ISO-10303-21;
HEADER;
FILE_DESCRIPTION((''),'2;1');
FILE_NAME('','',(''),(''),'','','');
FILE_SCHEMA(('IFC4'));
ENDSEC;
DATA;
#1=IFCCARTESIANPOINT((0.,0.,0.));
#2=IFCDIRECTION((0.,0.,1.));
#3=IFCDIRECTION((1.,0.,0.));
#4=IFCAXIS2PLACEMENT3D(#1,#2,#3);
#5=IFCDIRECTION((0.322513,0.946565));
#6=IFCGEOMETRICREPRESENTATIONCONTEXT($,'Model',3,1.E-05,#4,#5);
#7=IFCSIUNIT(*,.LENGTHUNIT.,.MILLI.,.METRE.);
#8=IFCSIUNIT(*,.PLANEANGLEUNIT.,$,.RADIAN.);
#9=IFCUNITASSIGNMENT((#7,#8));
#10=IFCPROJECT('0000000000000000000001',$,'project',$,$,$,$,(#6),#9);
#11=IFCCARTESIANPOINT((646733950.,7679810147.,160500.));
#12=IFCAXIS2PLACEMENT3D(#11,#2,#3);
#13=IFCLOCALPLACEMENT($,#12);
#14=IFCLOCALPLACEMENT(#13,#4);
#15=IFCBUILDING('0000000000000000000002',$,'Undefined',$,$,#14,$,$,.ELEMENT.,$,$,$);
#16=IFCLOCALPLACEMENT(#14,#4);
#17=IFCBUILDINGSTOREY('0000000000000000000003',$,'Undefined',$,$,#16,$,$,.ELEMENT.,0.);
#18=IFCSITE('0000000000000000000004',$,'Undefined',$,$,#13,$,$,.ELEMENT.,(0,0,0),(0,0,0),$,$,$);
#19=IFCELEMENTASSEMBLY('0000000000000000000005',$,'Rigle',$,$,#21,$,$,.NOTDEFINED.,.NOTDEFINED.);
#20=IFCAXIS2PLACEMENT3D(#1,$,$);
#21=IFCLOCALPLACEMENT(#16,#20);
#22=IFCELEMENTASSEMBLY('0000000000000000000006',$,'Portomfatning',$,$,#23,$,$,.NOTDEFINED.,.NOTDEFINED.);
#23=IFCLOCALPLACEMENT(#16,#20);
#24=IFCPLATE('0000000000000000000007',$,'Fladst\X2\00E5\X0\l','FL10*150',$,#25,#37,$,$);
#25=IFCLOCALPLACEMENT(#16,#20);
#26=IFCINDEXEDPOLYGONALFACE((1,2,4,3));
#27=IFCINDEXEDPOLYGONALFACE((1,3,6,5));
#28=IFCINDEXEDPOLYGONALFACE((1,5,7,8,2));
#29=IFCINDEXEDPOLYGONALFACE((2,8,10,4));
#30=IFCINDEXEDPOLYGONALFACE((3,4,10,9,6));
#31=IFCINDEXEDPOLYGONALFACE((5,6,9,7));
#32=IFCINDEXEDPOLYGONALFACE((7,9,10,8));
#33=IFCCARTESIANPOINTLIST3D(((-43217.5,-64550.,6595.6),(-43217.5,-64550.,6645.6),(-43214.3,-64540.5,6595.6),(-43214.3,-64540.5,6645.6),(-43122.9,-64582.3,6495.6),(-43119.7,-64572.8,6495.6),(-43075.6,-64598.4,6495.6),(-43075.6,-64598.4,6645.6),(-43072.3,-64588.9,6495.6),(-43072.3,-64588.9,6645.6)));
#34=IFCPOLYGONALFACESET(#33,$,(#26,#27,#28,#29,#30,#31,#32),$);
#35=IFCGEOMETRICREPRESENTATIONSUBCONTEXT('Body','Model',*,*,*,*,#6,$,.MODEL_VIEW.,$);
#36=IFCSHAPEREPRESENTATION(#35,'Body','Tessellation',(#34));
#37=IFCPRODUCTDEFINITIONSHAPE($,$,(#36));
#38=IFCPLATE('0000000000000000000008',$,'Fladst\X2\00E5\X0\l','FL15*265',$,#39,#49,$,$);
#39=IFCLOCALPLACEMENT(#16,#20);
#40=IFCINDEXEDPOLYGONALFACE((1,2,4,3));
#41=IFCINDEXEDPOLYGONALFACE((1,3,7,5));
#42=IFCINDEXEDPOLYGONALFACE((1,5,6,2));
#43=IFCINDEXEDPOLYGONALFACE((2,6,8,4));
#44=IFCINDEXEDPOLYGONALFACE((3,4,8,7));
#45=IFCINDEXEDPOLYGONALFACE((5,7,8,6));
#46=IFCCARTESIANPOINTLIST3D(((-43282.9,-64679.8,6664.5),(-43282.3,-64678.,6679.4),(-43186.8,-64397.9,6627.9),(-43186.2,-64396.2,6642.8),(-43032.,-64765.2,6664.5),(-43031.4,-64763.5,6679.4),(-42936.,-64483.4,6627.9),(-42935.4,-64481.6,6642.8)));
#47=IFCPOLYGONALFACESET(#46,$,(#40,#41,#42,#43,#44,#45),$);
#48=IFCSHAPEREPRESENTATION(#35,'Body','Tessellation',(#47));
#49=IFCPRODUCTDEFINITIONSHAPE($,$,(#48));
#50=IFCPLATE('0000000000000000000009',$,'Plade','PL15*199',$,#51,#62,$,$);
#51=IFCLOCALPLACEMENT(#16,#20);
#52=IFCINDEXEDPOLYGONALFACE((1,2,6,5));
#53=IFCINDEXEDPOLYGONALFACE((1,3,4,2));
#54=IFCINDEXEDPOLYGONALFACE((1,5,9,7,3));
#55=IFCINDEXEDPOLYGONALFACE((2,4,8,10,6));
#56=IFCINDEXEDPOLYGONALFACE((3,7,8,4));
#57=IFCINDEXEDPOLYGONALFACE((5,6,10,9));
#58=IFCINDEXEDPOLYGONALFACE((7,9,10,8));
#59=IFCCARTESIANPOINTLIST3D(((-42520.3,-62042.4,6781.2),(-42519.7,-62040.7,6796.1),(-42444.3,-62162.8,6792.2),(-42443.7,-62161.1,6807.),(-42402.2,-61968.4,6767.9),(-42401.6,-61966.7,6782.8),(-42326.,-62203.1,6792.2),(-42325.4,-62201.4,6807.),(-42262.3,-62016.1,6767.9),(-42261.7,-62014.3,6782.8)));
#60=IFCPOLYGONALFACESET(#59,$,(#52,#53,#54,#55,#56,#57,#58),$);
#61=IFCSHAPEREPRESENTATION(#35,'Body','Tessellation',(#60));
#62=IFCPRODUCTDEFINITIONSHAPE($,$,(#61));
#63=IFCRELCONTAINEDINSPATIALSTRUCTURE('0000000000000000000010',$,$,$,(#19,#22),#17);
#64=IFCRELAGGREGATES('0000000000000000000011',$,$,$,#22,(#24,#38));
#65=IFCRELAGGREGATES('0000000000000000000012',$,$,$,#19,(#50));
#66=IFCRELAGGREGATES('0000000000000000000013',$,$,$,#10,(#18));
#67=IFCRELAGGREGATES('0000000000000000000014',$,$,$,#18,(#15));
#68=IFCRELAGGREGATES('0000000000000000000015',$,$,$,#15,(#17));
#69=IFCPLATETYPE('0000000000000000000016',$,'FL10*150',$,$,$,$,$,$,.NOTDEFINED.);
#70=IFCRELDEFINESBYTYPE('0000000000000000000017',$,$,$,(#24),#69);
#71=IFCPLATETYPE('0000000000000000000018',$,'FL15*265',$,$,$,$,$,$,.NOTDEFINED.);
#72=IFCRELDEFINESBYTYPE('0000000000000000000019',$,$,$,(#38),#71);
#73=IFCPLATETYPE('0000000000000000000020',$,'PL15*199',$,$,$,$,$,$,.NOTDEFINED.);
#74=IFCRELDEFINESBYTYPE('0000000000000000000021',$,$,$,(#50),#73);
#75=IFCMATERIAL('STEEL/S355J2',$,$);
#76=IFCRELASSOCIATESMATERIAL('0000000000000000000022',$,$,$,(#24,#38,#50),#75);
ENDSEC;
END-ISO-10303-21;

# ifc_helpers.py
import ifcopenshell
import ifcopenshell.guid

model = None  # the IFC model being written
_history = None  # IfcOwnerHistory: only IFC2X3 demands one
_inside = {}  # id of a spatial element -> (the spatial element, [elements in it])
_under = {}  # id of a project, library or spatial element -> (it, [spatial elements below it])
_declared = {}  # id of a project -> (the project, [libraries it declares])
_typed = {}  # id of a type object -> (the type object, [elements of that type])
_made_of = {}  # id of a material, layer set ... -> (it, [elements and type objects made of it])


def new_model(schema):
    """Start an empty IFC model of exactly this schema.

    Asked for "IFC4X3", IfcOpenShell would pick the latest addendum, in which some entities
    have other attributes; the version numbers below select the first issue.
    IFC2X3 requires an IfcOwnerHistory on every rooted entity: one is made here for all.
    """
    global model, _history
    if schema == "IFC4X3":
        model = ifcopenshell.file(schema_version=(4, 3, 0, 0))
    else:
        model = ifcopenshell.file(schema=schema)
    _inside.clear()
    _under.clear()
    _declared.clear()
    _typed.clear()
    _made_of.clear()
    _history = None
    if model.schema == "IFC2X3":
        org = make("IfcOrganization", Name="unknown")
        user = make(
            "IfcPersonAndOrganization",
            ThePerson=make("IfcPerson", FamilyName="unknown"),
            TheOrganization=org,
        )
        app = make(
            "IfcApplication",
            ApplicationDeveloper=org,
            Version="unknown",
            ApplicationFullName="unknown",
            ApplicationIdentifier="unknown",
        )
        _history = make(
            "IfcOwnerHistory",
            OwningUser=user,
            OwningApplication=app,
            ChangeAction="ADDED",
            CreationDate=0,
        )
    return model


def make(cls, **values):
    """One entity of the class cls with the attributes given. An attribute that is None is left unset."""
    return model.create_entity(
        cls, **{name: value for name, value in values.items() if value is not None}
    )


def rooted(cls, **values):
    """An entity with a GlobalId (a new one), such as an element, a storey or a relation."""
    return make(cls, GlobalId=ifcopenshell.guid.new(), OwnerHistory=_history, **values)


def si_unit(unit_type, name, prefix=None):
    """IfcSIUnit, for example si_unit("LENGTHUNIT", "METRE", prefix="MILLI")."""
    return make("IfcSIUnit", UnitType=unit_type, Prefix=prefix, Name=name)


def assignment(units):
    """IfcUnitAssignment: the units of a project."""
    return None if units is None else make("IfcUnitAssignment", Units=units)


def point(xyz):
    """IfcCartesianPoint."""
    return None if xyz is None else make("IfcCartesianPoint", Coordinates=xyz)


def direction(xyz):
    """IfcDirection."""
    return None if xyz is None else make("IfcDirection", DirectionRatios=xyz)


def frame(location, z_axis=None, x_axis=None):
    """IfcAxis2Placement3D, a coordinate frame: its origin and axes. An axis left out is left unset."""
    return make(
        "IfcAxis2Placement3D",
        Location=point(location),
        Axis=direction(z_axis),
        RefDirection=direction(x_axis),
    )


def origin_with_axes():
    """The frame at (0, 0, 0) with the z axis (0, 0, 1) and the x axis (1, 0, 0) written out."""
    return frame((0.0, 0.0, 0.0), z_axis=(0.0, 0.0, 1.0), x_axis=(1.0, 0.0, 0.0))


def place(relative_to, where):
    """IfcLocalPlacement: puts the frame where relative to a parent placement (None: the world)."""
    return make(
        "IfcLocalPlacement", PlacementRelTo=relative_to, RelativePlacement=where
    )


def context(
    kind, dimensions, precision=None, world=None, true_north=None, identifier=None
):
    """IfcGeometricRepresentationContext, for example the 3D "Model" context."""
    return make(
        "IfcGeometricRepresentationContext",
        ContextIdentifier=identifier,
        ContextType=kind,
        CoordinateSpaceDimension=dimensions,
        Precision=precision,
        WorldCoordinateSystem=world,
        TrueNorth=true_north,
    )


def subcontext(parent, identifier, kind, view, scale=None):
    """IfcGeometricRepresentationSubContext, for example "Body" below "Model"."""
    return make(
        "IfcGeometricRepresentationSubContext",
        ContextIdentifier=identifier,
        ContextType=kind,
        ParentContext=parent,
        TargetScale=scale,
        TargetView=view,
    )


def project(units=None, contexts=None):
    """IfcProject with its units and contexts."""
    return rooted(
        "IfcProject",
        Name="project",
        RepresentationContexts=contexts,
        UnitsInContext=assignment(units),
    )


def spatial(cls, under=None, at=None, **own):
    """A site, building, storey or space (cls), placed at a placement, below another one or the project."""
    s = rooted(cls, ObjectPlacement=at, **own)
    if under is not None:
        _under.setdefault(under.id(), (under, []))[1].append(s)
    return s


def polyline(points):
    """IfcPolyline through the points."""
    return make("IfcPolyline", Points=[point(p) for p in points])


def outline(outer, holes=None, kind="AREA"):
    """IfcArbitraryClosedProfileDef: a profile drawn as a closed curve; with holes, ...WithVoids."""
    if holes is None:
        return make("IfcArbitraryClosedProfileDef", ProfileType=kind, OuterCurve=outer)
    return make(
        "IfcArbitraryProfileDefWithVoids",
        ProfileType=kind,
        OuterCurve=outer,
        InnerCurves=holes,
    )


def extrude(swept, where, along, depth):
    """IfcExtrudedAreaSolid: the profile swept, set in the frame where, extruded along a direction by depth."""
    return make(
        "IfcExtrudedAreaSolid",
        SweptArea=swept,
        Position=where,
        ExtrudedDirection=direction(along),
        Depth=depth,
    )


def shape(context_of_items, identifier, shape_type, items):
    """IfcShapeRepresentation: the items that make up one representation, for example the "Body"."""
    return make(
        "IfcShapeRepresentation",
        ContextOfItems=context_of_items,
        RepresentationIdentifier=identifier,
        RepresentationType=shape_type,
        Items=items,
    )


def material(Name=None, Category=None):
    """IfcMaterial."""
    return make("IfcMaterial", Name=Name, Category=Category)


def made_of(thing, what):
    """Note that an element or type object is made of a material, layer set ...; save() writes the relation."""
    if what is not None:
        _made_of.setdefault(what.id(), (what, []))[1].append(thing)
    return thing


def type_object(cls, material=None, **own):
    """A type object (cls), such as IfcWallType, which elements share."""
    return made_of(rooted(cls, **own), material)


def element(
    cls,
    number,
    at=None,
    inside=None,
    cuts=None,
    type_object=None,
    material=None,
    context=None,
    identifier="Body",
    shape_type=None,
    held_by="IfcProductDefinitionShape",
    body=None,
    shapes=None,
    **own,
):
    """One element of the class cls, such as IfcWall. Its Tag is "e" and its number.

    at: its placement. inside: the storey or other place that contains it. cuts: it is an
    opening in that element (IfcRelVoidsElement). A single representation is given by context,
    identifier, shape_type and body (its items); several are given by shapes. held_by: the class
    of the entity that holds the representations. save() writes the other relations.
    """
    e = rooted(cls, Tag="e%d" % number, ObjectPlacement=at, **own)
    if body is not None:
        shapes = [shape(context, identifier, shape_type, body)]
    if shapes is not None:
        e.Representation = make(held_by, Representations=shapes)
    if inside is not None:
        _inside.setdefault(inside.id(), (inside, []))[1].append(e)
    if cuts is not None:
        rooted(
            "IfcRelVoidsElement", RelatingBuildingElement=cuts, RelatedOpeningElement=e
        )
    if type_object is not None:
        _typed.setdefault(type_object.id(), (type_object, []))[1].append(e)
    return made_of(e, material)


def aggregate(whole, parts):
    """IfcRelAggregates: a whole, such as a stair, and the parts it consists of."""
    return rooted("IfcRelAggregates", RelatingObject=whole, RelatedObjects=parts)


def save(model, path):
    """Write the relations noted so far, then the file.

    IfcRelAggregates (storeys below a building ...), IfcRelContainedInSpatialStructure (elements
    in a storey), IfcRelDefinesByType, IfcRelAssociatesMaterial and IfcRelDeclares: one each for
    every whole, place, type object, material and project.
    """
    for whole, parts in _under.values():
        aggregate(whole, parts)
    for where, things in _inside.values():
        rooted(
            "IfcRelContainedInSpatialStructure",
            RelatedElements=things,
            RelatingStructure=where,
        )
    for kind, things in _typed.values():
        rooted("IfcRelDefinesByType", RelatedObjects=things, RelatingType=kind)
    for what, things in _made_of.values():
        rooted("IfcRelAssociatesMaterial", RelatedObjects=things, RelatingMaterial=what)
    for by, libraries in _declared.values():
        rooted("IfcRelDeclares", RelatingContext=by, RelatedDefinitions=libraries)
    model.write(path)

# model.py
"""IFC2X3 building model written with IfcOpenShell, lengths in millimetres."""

from ifc_helpers import new_model, si_unit, direction, frame, origin_with_axes, place, context, subcontext, project, spatial, polyline, outline, extrude, material, type_object, element, aggregate, save


model = new_model("IFC2X3")

# Units and contexts
model_context = context("Model", 3, precision=1e-05, world=origin_with_axes(), true_north=direction((0.322513, 0.946565)))
body_context = subcontext(model_context, "Body", "Model", "MODEL_VIEW")
ifc_project = project(units=[si_unit("LENGTHUNIT", "METRE", prefix="MILLI"), si_unit("PLANEANGLEUNIT", "RADIAN")], contexts=[model_context])

# Site, building, storey
site_placement = place(None, frame((646733950.0, 7679810147.0, 160500.0), z_axis=(0.0, 0.0, 1.0), x_axis=(1.0, 0.0, 0.0)))
site = spatial("IfcSite", under=ifc_project, at=site_placement, Name="Undefined", CompositionType="ELEMENT", RefLatitude=(0, 0, 0), RefLongitude=(0, 0, 0))
building_placement = place(site_placement, origin_with_axes())
building = spatial("IfcBuilding", under=site, at=building_placement, Name="Undefined", CompositionType="ELEMENT")
storey_placement = place(building_placement, origin_with_axes())
storey = spatial("IfcBuildingStorey", under=building, at=storey_placement, Name="Undefined", CompositionType="ELEMENT", Elevation=0.0)

# Shared definitions
ifc_material_1 = material(Name="STEEL/S355J2")

# Element assembly
assembly_1_placement = place(storey_placement, origin_with_axes())
assembly_1 = element("IfcElementAssembly", 1, at=assembly_1_placement, inside=storey, Name="Rigle", AssemblyPlace="NOTDEFINED", PredefinedType="NOTDEFINED")

# Element assembly, plates
assembly_2_placement = place(storey_placement, origin_with_axes())
assembly_2 = element("IfcElementAssembly", 2, at=assembly_2_placement, inside=storey, Name="Portomfatning", AssemblyPlace="NOTDEFINED", PredefinedType="NOTDEFINED")
plate_type_1 = type_object("IfcPlateType", Name="FL10*150", PredefinedType="NOTDEFINED")
plate_1_placement = place(assembly_2_placement, frame((-43073.9, -64593.7, 6645.6), z_axis=(0.322513, 0.946565, 0.0), x_axis=(0.0, 0.0, -1.0)))
plate_1 = element("IfcPlate", 3, at=plate_1_placement, type_object=plate_type_1, material=ifc_material_1, Name="Fladstål", Description="FL10*150", context=body_context, shape_type="SweptSolid", body=[
    extrude(outline(polyline([(0.0, 0.0), (150.0, 0.0), (150.0, 50.0), (50.0, 150.0), (0.0, 150.0), (0.0, 0.0)])), frame((0.0, 0.0, -5.0), z_axis=(0.0, 0.0, 1.0), x_axis=(1.0, 0.0, 0.0)), (0.0, 0.0, 1.0), 10.0),
])
plate_type_2 = type_object("IfcPlateType", Name="FL15*265", PredefinedType="NOTDEFINED")
plate_2_placement = place(assembly_2_placement, frame((-43061.1, -64439.8, 6635.4), z_axis=(-0.039304, -0.115357, -0.992546), x_axis=(-0.320109, -0.93951, 0.121869)))
plate_2 = element("IfcPlate", 4, at=plate_2_placement, type_object=plate_type_2, material=ifc_material_1, Name="Fladstål", Description="FL15*265", context=body_context, shape_type="SweptSolid", body=[
    extrude(outline(polyline([(0.0, -132.5), (0.0, 132.5), (300.0, 132.5), (300.0, -132.5), (0.0, -132.5)])), frame((0.0, 0.0, -7.5), z_axis=(0.0, 0.0, 1.0), x_axis=(1.0, 0.0, 0.0)), (0.0, 0.0, 1.0), 15.0),
])
aggregate(assembly_2, [plate_1, plate_2])

# Plate
plate_type_3 = type_object("IfcPlateType", Name="PL15*199", PredefinedType="NOTDEFINED")
plate_3_placement = place(assembly_1_placement, frame((-42325.7, -62202.2, 6799.6), z_axis=(0.039304, 0.115357, 0.992546), x_axis=(0.320109, 0.93951, -0.121869)))
plate_3 = element("IfcPlate", 5, at=plate_3_placement, type_object=plate_type_3, material=ifc_material_1, Name="Plade", Description="PL15*199", context=body_context, shape_type="SweptSolid", body=[
    extrude(outline(polyline([(0.0, 0.0), (199.1, 0.0), (199.1, 147.8), (90.1, 235.7), (0.0, 125.0), (0.0, 0.0)])), frame((0.0, 0.0, -7.5), z_axis=(0.0, 0.0, 1.0), x_axis=(1.0, 0.0, 0.0)), (0.0, 0.0, 1.0), 15.0),
])

aggregate(assembly_1, [plate_3])

save(model, "model.ifc")
